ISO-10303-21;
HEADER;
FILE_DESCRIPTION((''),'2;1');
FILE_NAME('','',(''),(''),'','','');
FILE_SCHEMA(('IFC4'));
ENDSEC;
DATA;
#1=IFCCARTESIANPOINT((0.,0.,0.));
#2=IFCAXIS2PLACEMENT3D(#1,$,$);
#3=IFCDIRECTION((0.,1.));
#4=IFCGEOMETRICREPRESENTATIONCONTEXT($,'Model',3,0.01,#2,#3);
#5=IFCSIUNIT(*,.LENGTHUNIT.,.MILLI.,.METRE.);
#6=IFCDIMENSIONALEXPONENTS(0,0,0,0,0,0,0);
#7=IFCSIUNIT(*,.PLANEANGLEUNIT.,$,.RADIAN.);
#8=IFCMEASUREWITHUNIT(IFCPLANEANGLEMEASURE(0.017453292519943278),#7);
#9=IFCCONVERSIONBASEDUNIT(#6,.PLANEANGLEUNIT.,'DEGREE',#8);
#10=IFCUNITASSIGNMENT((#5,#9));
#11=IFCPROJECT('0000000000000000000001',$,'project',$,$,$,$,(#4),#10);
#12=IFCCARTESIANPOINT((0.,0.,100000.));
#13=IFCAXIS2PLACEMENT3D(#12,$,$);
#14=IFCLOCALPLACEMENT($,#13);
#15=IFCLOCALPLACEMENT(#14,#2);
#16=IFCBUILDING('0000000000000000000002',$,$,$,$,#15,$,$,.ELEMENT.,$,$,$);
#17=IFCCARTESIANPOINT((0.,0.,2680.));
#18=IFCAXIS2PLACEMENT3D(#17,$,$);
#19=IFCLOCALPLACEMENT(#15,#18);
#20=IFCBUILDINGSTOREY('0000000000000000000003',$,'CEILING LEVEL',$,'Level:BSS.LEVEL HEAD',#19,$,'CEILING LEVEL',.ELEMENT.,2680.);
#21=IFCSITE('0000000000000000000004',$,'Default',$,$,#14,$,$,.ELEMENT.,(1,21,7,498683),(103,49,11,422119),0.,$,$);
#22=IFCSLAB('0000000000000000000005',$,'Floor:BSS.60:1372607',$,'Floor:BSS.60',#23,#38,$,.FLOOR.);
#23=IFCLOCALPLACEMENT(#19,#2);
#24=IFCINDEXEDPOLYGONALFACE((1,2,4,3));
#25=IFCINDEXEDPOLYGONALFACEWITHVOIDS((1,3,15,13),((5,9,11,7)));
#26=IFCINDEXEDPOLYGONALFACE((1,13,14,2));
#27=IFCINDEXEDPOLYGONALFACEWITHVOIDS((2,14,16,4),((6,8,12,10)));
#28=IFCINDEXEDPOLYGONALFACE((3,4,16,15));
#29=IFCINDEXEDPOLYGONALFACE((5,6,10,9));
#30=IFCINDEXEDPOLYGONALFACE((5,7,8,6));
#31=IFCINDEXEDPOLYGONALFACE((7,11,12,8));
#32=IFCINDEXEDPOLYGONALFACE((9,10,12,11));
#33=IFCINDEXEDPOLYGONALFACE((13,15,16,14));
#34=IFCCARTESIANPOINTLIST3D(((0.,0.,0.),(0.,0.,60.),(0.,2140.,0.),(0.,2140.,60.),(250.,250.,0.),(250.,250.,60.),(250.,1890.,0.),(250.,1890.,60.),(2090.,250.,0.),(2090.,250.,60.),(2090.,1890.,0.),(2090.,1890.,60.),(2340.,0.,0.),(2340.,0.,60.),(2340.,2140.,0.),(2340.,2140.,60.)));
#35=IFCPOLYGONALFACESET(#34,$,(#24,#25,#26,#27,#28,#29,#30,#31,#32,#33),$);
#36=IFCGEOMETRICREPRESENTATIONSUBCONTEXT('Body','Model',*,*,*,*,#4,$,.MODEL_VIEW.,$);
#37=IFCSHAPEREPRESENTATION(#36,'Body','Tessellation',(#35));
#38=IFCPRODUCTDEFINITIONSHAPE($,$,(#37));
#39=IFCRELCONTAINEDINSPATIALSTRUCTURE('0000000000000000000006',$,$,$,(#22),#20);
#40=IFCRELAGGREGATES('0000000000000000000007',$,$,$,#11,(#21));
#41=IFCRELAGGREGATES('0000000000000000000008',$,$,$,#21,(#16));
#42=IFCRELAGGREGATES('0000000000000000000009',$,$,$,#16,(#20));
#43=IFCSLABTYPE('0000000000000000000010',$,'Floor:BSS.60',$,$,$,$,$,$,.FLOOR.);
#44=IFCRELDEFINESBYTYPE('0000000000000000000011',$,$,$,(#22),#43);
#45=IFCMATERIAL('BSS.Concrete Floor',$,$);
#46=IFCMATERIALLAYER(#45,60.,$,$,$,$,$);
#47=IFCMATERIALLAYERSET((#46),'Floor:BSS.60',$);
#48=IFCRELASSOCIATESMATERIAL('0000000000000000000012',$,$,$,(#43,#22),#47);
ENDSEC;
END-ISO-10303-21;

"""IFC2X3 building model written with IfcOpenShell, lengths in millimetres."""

from ifc_helpers import new_model, entity, si_unit, converted_unit, direction, frame, frame_2d, origin, origin_2d_with_axis, place, context, subcontext, project, spatial, rectangle, extrude, material, layer, layer_set, layer_usage, type_object, element, save


model = new_model("IFC2X3")

# Units and contexts
model_context = context("Model", 3, precision=0.01, world=origin(), true_north=direction((0.0, 1.0)))
body_context = subcontext(model_context, "Body", "Model", "MODEL_VIEW")
ifc_project = project(units=[si_unit("LENGTHUNIT", "METRE", prefix="MILLI"), converted_unit("PLANEANGLEUNIT", "DEGREE", entity("IfcPlaneAngleMeasure", 0.017453292519943278), si_unit("PLANEANGLEUNIT", "RADIAN"), dimensions=[0, 0, 0, 0, 0, 0, 0])], contexts=[model_context])

# Site, building, storey
site_placement = place(None, frame((0.0, 0.0, 100000.0)))
site = spatial("IfcSite", under=ifc_project, at=site_placement, Name="Default", CompositionType="ELEMENT", RefLatitude=(1, 21, 7, 498683), RefLongitude=(103, 49, 11, 422119), RefElevation=0.0)
building_placement = place(site_placement, origin())
building = spatial("IfcBuilding", under=site, at=building_placement, CompositionType="ELEMENT")
storey_placement = place(building_placement, frame((0.0, 0.0, 2680.0)))
storey = spatial("IfcBuildingStorey", under=building, at=storey_placement, Name="CEILING LEVEL", ObjectType="Level:BSS.LEVEL HEAD", LongName="CEILING LEVEL", CompositionType="ELEMENT", Elevation=2680.0)

# Slab, opening
ifc_material = material(Name="BSS.Concrete Floor")
ifc_layer = layer(ifc_material, 60.0)
ifc_layer_set = layer_set([ifc_layer], Name="Floor:BSS.60")
ifc_layer_usage = layer_usage(ifc_layer_set, "AXIS3", "POSITIVE", 0.0)
slab_type = type_object("IfcSlabType", Name="Floor:BSS.60", PredefinedType="FLOOR", material=ifc_layer_set)
slab_placement = place(storey_placement, origin())
slab = element("IfcSlab", 1, at=slab_placement, inside=storey, type_object=slab_type, material=ifc_layer_usage, Name="Floor:BSS.60:1372607", ObjectType="Floor:BSS.60", PredefinedType="FLOOR", context=body_context, shape_type="SweptSolid", body=[
    extrude(rectangle(XDim=2140.0, YDim=2340.0, at=frame_2d((0.0, 0.0), x_axis=(0.0, 1.0))), frame((1170.0, 1070.0, 60.0), z_axis=(0.0, 0.0, -1.0), x_axis=(-1.0, 0.0, 0.0)), (0.0, 0.0, 1.0), 60.0),
])
opening_placement = place(slab_placement, origin())
element("IfcOpeningElement", 2, at=opening_placement, cuts=slab, ObjectType="Opening", context=body_context, shape_type="SweptSolid", body=[
    extrude(rectangle(XDim=1640.0, YDim=1840.0, at=origin_2d_with_axis()), frame((1170.0, 1070.0, 60.0), z_axis=(0.0, 0.0, -1.0), x_axis=(0.0, 1.0, 0.0)), (0.0, 0.0, 1.0), 60.0),
])

save(model, "model.ifc")
